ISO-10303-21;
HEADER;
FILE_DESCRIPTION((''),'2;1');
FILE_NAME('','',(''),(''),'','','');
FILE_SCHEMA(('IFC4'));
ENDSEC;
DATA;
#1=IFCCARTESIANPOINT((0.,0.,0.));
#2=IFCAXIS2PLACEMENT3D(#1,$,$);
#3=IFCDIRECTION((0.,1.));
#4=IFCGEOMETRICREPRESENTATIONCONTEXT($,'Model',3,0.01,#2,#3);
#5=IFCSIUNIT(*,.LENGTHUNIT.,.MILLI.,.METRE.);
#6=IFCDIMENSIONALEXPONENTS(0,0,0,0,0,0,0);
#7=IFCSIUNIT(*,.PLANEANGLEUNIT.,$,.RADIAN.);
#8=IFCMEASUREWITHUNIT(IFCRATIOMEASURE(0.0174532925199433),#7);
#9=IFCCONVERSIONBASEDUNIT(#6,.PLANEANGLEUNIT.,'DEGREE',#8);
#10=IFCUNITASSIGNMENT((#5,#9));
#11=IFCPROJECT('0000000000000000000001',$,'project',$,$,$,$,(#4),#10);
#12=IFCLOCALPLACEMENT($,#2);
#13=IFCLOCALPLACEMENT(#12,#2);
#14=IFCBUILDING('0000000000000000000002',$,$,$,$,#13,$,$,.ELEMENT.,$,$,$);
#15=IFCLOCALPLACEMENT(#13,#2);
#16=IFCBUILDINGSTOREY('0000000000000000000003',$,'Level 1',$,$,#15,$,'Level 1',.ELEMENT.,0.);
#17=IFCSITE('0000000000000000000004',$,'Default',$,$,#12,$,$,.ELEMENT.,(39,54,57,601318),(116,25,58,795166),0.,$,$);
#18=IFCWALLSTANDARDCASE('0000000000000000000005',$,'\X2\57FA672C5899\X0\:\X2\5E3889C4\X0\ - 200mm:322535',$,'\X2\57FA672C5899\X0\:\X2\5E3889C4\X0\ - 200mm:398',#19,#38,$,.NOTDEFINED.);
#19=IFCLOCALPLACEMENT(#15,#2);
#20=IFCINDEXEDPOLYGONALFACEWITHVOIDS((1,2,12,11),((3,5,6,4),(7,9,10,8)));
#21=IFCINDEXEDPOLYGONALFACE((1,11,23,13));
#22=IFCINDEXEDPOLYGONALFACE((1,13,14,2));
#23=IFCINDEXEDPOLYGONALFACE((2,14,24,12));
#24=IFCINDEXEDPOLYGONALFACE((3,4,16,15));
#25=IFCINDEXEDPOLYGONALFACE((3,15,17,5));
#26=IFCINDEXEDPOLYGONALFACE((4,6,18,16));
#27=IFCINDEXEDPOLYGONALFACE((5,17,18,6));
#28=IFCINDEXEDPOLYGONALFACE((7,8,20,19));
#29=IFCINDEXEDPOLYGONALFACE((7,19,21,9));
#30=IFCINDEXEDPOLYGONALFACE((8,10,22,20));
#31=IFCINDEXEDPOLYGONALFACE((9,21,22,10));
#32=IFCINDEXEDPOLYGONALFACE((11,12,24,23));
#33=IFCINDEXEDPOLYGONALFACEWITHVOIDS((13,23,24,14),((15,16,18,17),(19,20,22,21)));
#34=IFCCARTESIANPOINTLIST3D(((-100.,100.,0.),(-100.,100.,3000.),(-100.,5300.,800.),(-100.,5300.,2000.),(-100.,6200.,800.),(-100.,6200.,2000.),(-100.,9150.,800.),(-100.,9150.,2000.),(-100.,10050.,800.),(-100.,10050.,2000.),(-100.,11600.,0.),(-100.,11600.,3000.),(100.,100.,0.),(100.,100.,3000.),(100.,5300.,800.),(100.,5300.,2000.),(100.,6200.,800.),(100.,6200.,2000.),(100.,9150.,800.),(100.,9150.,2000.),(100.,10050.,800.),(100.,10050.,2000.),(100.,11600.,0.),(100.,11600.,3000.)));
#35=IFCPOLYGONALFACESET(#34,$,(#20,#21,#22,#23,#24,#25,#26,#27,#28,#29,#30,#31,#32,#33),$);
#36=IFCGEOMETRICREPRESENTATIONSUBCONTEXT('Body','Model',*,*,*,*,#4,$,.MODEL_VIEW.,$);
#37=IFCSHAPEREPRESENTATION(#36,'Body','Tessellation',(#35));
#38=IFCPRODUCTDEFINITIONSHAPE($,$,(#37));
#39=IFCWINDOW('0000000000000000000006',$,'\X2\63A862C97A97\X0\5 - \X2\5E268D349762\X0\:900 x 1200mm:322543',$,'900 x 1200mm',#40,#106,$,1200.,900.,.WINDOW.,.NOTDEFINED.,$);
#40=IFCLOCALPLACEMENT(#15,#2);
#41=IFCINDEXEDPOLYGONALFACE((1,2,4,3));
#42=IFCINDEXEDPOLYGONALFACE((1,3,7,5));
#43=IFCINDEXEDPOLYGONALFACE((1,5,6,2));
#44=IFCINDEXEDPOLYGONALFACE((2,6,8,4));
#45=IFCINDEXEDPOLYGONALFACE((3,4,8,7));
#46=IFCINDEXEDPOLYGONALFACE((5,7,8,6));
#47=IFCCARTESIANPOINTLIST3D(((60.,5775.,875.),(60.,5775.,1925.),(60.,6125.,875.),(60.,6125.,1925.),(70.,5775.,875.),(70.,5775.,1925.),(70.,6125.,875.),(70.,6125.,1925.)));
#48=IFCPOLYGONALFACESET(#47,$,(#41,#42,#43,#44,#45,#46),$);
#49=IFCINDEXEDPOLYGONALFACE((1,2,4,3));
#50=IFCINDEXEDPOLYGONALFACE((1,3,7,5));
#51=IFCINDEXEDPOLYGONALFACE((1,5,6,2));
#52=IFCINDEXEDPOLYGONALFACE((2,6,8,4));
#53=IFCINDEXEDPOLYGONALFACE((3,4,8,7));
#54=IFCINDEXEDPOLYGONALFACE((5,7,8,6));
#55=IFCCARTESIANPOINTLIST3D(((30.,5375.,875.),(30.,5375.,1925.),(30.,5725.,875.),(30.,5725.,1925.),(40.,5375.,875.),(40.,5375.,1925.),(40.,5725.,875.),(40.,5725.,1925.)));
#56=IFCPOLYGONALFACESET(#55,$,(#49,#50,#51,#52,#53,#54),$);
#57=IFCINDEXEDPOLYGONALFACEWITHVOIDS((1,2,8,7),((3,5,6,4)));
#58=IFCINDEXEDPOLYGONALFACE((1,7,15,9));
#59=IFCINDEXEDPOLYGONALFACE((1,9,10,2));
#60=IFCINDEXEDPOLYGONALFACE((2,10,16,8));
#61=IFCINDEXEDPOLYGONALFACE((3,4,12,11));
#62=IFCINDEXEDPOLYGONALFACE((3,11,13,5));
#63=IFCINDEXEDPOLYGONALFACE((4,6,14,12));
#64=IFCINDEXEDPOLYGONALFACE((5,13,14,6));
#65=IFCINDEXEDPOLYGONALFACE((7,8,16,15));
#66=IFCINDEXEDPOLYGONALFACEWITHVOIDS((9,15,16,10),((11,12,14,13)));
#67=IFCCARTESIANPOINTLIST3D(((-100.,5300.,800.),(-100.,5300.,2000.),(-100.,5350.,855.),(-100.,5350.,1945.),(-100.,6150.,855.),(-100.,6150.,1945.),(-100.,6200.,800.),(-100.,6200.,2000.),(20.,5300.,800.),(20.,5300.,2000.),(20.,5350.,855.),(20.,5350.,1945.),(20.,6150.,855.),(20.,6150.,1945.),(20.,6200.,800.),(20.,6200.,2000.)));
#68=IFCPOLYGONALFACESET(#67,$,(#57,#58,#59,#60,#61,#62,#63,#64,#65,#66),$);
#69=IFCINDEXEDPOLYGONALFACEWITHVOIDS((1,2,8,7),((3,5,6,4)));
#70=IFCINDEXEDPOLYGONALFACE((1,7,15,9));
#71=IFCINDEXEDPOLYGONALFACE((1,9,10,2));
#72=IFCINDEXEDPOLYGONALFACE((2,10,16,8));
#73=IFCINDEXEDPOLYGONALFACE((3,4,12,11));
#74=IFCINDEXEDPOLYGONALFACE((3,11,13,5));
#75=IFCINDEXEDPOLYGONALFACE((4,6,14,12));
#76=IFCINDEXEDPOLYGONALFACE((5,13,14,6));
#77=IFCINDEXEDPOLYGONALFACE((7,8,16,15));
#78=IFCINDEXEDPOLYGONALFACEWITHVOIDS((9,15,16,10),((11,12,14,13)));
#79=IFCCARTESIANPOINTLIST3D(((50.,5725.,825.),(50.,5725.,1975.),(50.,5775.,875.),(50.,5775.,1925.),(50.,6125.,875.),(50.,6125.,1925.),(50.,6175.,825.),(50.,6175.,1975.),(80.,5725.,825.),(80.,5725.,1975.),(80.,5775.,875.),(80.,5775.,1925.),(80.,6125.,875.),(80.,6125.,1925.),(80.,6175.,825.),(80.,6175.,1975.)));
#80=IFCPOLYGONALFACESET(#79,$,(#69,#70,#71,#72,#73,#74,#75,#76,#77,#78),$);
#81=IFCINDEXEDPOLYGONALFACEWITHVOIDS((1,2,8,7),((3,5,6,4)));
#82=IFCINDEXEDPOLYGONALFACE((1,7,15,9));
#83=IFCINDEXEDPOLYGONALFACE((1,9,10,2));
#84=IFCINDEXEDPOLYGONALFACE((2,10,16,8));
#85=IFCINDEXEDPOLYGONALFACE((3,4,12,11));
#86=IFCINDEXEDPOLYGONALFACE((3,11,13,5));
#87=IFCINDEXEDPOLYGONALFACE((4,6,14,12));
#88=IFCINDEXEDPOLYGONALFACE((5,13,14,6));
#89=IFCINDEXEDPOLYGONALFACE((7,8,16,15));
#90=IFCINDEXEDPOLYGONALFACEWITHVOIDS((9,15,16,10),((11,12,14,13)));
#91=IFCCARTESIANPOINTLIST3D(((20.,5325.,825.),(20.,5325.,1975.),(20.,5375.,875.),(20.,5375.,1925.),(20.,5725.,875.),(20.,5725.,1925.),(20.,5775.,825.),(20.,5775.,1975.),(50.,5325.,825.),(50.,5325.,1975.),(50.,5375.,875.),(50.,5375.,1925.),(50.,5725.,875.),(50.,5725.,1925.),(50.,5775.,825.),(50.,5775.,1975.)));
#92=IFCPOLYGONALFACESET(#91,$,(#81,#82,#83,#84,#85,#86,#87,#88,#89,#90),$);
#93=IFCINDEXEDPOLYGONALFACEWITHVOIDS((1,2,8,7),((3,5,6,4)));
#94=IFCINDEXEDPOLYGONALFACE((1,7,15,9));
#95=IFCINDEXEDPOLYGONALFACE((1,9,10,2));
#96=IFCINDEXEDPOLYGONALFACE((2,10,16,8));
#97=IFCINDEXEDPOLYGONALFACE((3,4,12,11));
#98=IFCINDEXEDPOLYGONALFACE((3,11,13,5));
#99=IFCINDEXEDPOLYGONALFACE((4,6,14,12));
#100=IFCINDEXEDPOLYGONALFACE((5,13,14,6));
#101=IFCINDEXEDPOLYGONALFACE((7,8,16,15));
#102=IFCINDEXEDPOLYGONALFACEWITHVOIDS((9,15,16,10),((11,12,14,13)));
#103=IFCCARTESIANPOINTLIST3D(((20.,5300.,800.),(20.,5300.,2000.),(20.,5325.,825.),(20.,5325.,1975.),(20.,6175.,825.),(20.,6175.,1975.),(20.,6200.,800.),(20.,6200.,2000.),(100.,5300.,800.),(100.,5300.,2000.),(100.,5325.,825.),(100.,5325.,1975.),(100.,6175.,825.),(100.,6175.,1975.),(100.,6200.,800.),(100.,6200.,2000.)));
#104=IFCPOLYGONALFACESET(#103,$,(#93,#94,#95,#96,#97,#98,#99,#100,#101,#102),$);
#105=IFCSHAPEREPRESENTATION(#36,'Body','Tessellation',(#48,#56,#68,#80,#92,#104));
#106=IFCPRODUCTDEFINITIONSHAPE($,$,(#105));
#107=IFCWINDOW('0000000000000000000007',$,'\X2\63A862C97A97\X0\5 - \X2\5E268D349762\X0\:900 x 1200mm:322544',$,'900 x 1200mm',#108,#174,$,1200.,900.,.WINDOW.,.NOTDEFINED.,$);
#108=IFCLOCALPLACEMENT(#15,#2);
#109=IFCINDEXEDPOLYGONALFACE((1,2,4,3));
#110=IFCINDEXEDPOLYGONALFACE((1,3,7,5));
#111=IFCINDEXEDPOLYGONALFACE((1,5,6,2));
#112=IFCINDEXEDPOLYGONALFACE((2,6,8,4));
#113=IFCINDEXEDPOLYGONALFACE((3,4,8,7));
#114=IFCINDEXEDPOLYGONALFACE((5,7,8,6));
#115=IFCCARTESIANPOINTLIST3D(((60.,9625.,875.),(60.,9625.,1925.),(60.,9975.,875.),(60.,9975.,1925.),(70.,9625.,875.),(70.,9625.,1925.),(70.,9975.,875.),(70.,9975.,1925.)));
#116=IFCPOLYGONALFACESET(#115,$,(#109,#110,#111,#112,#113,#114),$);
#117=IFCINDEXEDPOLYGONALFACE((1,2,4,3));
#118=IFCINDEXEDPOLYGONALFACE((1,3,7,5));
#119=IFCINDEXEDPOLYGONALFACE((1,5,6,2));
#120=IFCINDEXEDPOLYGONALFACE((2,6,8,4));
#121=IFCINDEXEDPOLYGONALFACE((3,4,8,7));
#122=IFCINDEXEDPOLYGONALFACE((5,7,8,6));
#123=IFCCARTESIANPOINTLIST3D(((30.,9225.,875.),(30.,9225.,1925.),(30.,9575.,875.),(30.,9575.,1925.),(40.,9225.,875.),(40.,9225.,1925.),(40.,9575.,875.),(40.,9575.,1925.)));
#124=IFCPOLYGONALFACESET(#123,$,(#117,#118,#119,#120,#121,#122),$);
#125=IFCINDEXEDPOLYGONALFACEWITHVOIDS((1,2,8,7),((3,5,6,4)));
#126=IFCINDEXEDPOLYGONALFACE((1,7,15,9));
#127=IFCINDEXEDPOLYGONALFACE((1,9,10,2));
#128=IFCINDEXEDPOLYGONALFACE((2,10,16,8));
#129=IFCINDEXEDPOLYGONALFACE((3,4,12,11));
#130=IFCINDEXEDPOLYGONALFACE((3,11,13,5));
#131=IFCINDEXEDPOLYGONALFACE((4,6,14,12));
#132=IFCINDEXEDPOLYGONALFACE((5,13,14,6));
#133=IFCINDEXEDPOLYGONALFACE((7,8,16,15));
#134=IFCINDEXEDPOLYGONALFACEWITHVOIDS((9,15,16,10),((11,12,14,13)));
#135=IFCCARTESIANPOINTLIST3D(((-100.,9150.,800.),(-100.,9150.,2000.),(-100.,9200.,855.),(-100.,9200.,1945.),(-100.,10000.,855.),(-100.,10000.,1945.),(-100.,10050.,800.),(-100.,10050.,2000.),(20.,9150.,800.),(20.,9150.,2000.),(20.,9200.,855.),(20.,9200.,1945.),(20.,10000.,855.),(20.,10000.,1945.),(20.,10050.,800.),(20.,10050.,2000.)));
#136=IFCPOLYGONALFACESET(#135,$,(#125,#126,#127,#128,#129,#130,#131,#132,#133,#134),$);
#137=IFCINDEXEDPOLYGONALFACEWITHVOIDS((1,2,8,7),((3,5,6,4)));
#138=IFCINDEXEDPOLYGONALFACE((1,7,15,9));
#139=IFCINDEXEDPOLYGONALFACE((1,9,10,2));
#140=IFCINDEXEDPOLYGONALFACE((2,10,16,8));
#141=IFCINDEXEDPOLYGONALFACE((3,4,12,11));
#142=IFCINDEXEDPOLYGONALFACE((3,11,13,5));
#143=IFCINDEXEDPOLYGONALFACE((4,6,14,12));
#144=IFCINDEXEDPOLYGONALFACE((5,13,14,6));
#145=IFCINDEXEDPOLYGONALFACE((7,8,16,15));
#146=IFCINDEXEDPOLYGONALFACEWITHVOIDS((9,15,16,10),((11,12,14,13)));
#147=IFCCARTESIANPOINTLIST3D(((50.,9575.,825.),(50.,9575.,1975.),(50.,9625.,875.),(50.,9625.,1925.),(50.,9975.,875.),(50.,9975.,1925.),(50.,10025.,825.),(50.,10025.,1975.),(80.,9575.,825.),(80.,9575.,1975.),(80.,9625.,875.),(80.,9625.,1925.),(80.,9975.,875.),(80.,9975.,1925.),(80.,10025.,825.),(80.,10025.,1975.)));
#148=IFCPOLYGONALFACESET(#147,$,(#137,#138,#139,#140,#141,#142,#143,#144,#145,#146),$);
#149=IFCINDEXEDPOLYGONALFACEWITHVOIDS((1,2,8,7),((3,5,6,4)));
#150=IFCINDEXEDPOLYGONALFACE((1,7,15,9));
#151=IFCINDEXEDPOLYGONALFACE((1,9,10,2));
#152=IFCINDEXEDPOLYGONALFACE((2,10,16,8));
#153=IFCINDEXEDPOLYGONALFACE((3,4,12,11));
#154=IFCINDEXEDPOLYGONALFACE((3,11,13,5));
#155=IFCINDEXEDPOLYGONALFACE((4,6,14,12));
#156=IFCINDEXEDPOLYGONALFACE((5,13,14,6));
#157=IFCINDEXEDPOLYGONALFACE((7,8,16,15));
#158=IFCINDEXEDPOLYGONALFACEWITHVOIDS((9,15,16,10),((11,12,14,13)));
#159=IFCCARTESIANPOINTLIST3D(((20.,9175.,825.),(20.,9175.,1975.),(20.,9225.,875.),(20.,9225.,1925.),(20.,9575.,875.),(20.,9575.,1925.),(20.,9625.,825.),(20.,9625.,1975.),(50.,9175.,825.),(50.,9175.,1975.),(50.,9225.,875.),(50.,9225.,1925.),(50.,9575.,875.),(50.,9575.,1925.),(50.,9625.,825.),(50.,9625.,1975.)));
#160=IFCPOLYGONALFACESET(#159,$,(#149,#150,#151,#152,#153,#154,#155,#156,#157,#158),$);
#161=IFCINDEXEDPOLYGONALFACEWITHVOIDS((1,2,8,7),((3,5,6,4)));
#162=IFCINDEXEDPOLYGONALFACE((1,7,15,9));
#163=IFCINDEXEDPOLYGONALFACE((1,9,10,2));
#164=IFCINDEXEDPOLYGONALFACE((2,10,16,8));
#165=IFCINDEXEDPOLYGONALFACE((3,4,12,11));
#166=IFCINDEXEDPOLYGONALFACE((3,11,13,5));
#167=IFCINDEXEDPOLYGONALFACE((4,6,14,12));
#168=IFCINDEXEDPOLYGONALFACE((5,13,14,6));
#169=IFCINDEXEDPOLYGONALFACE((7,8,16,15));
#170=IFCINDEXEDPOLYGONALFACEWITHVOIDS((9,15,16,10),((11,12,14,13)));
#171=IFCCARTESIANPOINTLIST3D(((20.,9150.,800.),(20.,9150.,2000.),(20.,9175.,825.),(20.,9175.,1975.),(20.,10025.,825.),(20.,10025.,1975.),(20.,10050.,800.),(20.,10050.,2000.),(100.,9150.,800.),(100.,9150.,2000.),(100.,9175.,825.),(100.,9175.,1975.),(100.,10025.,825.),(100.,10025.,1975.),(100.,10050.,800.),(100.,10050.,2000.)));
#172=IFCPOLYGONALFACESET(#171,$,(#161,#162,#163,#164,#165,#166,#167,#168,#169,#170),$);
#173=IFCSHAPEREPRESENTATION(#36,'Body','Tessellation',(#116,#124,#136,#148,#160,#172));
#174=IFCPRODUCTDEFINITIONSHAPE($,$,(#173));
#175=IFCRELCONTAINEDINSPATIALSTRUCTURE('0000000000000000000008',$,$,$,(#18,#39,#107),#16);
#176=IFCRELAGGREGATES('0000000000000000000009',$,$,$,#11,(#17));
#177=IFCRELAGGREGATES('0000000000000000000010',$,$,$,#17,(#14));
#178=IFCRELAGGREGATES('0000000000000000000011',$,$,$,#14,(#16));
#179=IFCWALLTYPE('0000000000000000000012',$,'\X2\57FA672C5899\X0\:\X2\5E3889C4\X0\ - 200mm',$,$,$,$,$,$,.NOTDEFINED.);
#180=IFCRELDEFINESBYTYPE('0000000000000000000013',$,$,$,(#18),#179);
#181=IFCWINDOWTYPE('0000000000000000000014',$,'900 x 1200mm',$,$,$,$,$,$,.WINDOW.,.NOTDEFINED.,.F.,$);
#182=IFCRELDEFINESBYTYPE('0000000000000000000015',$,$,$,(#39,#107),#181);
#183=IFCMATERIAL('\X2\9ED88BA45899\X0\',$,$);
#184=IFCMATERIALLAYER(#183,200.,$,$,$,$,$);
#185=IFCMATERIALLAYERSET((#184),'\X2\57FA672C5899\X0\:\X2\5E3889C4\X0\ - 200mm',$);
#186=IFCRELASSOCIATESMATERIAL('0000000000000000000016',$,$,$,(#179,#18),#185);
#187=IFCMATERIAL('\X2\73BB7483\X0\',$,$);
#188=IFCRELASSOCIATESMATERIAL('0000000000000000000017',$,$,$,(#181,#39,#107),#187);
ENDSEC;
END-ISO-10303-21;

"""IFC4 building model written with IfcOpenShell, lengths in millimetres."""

from ifc_helpers import new_model, entity, si_unit, converted_unit, direction, frame, frame_2d, origin, origin_2d_with_axis, place, context, subcontext, project, spatial, polyline, rectangle, outline, extrude, source, transform, mapped, material, layer, layer_set, layer_usage, type_object, type_shapes, element, fill, save


model = new_model("IFC4")

# Units and contexts
model_context_1 = context("Model", 3, precision=0.01, world=origin(), true_north=direction((0.0, 1.0)))
body_context_1 = subcontext(model_context_1, "Body", "Model", "MODEL_VIEW")
ifc_project = project(units=[si_unit("LENGTHUNIT", "METRE", prefix="MILLI"), converted_unit("PLANEANGLEUNIT", "DEGREE", entity("IfcRatioMeasure", 0.0174532925199433), si_unit("PLANEANGLEUNIT", "RADIAN"), dimensions=[0, 0, 0, 0, 0, 0, 0])], contexts=[model_context_1])

# Site, building, storey
site_placement = place(None, origin())
site = spatial("IfcSite", under=ifc_project, at=site_placement, Name="Default", CompositionType="ELEMENT", RefLatitude=(39, 54, 57, 601318), RefLongitude=(116, 25, 58, 795166), RefElevation=0.0)
building_placement = place(site_placement, origin())
building = spatial("IfcBuilding", under=site, at=building_placement, CompositionType="ELEMENT")
storey_placement = place(building_placement, origin())
storey = spatial("IfcBuildingStorey", under=building, at=storey_placement, Name="Level 1", LongName="Level 1", CompositionType="ELEMENT", Elevation=0.0)

# Wall, openings, windows
ifc_material_1 = material(Name="默认墙")
ifc_layer_1 = layer(ifc_material_1, 200.0)
ifc_layer_set_1 = layer_set([ifc_layer_1], Name="基本墙:常规 - 200mm")
ifc_layer_usage_1 = layer_usage(ifc_layer_set_1, "AXIS2", "NEGATIVE", 100.0)
wall_type = type_object("IfcWallType", Name="基本墙:常规 - 200mm", PredefinedType="NOTDEFINED", material=ifc_layer_set_1)
wall_1_placement = place(storey_placement, frame((0.0, 100.0, 0.0), z_axis=(0.0, 0.0, 1.0), x_axis=(0.0, 1.0, 0.0)))
wall_1 = element("IfcWallStandardCase", 1, at=wall_1_placement, inside=storey, type_object=wall_type, material=ifc_layer_usage_1, Name="基本墙:常规 - 200mm:322535", ObjectType="基本墙:常规 - 200mm:398", PredefinedType="NOTDEFINED", context=body_context_1, shape_type="SweptSolid", body=[
    extrude(rectangle(XDim=11500.0, YDim=200.0, at=frame_2d((5750.0, 0.0), x_axis=(-1.0, 0.0))), origin(), (0.0, 0.0, 1.0), 3000.0),
])
opening_1_placement = place(wall_1_placement, frame((6100.0, 100.0, 800.0)))
opening_1 = element("IfcOpeningElement", 2, at=opening_1_placement, cuts=wall_1, ObjectType="Opening", PredefinedType="OPENING", context=body_context_1, shape_type="SweptSolid", body=[
    extrude(rectangle(XDim=1200.0, YDim=900.0, at=frame_2d((600.0, 450.0), x_axis=(-1.0, 0.0))), frame((0.0, 0.0, 0.0), z_axis=(0.0, -1.0, 0.0), x_axis=(0.0, 0.0, 1.0)), (0.0, 0.0, 1.0), 200.0),
])
opening_2_placement = place(wall_1_placement, frame((9950.0, 100.0, 800.0)))
opening_2 = element("IfcOpeningElement", 3, at=opening_2_placement, cuts=wall_1, ObjectType="Opening", PredefinedType="OPENING", context=body_context_1, shape_type="SweptSolid", body=[
    extrude(rectangle(XDim=1200.0, YDim=900.0, at=frame_2d((600.0, 450.0), x_axis=(-1.0, 0.0))), frame((0.0, 0.0, 0.0), z_axis=(0.0, -1.0, 0.0), x_axis=(0.0, 0.0, 1.0)), (0.0, 0.0, 1.0), 200.0),
])
ifc_material_2 = material(Name="玻璃")
window_type_1 = type_object("IfcWindowType", Name="900 x 1200mm", ParameterTakesPrecedence=False, PartitioningType="NOTDEFINED", PredefinedType="WINDOW", material=ifc_material_2)
shared_shape_1 = source(origin(), body_context_1, "Body", "SweptSolid", [
    extrude(rectangle(XDim=10.0, YDim=350.0, at=origin_2d_with_axis()), frame((250.0, 165.0, 75.0), z_axis=(0.0, 0.0, 1.0), x_axis=(0.0, -1.0, 0.0)), (0.0, 0.0, 1.0), 1050.0),
    extrude(rectangle(XDim=10.0, YDim=350.0, at=frame_2d((0.0, 0.0), x_axis=(1.0, 0.0))), frame((650.0, 135.0, 75.0), z_axis=(0.0, 0.0, 1.0), x_axis=(0.0, -1.0, 0.0)), (0.0, 0.0, 1.0), 1050.0),
    extrude(outline(polyline([(-450.0, -600.0), (450.0, -600.0), (450.0, 600.0), (-450.0, 600.0), (-450.0, -600.0)]), holes=[polyline([(400.0, -545.0), (-400.0, -545.0), (-400.0, 545.0), (400.0, 545.0), (400.0, -545.0)])]), frame((450.0, 0.0, 600.0), z_axis=(0.0, 1.0, 0.0), x_axis=(1.0, 0.0, 0.0)), (0.0, 0.0, 1.0), 120.0),
    extrude(outline(polyline([(-225.0, -575.0), (225.0, -575.0), (225.0, 575.0), (-225.0, 575.0), (-225.0, -575.0)]), holes=[polyline([(-175.0, -525.0), (-175.0, 525.0), (175.0, 525.0), (175.0, -525.0), (-175.0, -525.0)])]), frame((250.0, 150.0, 600.0), z_axis=(0.0, 1.0, 0.0), x_axis=(-1.0, 0.0, 0.0)), (0.0, 0.0, 1.0), 30.0),
    extrude(outline(polyline([(-225.0, -575.0), (225.0, -575.0), (225.0, 575.0), (-225.0, 575.0), (-225.0, -575.0)]), holes=[polyline([(-175.0, -525.0), (-175.0, 525.0), (175.0, 525.0), (175.0, -525.0), (-175.0, -525.0)])]), frame((650.0, 120.0, 600.0), z_axis=(0.0, 1.0, 0.0), x_axis=(1.0, 0.0, 0.0)), (0.0, 0.0, 1.0), 30.0),
    extrude(outline(polyline([(-450.0, -600.0), (450.0, -600.0), (450.0, 600.0), (-450.0, 600.0), (-450.0, -600.0)]), holes=[polyline([(-425.0, 575.0), (425.0, 575.0), (425.0, -575.0), (-425.0, -575.0), (-425.0, 575.0)])]), frame((450.0, 120.0, 600.0), z_axis=(0.0, 1.0, 0.0), x_axis=(1.0, 0.0, 0.0)), (0.0, 0.0, 1.0), 80.0),
])
type_shapes(window_type_1, [shared_shape_1])
window_1_placement = place(opening_1_placement, frame((0.0, 0.0, 0.0), z_axis=(0.0, 0.0, 1.0), x_axis=(-1.0, 0.0, 0.0)))
window_1 = element("IfcWindow", 4, at=window_1_placement, inside=storey, type_object=window_type_1, material=ifc_material_2, Name="推拉窗5 - 带贴面:900 x 1200mm:322543", ObjectType="900 x 1200mm", OverallHeight=1200.0, OverallWidth=900.0, PartitioningType="NOTDEFINED", PredefinedType="WINDOW", context=body_context_1, shape_type="MappedRepresentation", body=[
    mapped(shared_shape_1, transform((0.0, 0.0, 0.0), scale=1.0)),
])
fill(opening_1, window_1)
window_2_placement = place(opening_2_placement, frame((0.0, 0.0, 0.0), z_axis=(0.0, 0.0, 1.0), x_axis=(-1.0, 0.0, 0.0)))
window_2 = element("IfcWindow", 5, at=window_2_placement, inside=storey, type_object=window_type_1, material=ifc_material_2, Name="推拉窗5 - 带贴面:900 x 1200mm:322544", ObjectType="900 x 1200mm", OverallHeight=1200.0, OverallWidth=900.0, PartitioningType="NOTDEFINED", PredefinedType="WINDOW", context=body_context_1, shape_type="MappedRepresentation", body=[
    mapped(shared_shape_1, transform((0.0, 0.0, 0.0), scale=1.0)),
])
fill(opening_2, window_2)

save(model, "model.ifc")
